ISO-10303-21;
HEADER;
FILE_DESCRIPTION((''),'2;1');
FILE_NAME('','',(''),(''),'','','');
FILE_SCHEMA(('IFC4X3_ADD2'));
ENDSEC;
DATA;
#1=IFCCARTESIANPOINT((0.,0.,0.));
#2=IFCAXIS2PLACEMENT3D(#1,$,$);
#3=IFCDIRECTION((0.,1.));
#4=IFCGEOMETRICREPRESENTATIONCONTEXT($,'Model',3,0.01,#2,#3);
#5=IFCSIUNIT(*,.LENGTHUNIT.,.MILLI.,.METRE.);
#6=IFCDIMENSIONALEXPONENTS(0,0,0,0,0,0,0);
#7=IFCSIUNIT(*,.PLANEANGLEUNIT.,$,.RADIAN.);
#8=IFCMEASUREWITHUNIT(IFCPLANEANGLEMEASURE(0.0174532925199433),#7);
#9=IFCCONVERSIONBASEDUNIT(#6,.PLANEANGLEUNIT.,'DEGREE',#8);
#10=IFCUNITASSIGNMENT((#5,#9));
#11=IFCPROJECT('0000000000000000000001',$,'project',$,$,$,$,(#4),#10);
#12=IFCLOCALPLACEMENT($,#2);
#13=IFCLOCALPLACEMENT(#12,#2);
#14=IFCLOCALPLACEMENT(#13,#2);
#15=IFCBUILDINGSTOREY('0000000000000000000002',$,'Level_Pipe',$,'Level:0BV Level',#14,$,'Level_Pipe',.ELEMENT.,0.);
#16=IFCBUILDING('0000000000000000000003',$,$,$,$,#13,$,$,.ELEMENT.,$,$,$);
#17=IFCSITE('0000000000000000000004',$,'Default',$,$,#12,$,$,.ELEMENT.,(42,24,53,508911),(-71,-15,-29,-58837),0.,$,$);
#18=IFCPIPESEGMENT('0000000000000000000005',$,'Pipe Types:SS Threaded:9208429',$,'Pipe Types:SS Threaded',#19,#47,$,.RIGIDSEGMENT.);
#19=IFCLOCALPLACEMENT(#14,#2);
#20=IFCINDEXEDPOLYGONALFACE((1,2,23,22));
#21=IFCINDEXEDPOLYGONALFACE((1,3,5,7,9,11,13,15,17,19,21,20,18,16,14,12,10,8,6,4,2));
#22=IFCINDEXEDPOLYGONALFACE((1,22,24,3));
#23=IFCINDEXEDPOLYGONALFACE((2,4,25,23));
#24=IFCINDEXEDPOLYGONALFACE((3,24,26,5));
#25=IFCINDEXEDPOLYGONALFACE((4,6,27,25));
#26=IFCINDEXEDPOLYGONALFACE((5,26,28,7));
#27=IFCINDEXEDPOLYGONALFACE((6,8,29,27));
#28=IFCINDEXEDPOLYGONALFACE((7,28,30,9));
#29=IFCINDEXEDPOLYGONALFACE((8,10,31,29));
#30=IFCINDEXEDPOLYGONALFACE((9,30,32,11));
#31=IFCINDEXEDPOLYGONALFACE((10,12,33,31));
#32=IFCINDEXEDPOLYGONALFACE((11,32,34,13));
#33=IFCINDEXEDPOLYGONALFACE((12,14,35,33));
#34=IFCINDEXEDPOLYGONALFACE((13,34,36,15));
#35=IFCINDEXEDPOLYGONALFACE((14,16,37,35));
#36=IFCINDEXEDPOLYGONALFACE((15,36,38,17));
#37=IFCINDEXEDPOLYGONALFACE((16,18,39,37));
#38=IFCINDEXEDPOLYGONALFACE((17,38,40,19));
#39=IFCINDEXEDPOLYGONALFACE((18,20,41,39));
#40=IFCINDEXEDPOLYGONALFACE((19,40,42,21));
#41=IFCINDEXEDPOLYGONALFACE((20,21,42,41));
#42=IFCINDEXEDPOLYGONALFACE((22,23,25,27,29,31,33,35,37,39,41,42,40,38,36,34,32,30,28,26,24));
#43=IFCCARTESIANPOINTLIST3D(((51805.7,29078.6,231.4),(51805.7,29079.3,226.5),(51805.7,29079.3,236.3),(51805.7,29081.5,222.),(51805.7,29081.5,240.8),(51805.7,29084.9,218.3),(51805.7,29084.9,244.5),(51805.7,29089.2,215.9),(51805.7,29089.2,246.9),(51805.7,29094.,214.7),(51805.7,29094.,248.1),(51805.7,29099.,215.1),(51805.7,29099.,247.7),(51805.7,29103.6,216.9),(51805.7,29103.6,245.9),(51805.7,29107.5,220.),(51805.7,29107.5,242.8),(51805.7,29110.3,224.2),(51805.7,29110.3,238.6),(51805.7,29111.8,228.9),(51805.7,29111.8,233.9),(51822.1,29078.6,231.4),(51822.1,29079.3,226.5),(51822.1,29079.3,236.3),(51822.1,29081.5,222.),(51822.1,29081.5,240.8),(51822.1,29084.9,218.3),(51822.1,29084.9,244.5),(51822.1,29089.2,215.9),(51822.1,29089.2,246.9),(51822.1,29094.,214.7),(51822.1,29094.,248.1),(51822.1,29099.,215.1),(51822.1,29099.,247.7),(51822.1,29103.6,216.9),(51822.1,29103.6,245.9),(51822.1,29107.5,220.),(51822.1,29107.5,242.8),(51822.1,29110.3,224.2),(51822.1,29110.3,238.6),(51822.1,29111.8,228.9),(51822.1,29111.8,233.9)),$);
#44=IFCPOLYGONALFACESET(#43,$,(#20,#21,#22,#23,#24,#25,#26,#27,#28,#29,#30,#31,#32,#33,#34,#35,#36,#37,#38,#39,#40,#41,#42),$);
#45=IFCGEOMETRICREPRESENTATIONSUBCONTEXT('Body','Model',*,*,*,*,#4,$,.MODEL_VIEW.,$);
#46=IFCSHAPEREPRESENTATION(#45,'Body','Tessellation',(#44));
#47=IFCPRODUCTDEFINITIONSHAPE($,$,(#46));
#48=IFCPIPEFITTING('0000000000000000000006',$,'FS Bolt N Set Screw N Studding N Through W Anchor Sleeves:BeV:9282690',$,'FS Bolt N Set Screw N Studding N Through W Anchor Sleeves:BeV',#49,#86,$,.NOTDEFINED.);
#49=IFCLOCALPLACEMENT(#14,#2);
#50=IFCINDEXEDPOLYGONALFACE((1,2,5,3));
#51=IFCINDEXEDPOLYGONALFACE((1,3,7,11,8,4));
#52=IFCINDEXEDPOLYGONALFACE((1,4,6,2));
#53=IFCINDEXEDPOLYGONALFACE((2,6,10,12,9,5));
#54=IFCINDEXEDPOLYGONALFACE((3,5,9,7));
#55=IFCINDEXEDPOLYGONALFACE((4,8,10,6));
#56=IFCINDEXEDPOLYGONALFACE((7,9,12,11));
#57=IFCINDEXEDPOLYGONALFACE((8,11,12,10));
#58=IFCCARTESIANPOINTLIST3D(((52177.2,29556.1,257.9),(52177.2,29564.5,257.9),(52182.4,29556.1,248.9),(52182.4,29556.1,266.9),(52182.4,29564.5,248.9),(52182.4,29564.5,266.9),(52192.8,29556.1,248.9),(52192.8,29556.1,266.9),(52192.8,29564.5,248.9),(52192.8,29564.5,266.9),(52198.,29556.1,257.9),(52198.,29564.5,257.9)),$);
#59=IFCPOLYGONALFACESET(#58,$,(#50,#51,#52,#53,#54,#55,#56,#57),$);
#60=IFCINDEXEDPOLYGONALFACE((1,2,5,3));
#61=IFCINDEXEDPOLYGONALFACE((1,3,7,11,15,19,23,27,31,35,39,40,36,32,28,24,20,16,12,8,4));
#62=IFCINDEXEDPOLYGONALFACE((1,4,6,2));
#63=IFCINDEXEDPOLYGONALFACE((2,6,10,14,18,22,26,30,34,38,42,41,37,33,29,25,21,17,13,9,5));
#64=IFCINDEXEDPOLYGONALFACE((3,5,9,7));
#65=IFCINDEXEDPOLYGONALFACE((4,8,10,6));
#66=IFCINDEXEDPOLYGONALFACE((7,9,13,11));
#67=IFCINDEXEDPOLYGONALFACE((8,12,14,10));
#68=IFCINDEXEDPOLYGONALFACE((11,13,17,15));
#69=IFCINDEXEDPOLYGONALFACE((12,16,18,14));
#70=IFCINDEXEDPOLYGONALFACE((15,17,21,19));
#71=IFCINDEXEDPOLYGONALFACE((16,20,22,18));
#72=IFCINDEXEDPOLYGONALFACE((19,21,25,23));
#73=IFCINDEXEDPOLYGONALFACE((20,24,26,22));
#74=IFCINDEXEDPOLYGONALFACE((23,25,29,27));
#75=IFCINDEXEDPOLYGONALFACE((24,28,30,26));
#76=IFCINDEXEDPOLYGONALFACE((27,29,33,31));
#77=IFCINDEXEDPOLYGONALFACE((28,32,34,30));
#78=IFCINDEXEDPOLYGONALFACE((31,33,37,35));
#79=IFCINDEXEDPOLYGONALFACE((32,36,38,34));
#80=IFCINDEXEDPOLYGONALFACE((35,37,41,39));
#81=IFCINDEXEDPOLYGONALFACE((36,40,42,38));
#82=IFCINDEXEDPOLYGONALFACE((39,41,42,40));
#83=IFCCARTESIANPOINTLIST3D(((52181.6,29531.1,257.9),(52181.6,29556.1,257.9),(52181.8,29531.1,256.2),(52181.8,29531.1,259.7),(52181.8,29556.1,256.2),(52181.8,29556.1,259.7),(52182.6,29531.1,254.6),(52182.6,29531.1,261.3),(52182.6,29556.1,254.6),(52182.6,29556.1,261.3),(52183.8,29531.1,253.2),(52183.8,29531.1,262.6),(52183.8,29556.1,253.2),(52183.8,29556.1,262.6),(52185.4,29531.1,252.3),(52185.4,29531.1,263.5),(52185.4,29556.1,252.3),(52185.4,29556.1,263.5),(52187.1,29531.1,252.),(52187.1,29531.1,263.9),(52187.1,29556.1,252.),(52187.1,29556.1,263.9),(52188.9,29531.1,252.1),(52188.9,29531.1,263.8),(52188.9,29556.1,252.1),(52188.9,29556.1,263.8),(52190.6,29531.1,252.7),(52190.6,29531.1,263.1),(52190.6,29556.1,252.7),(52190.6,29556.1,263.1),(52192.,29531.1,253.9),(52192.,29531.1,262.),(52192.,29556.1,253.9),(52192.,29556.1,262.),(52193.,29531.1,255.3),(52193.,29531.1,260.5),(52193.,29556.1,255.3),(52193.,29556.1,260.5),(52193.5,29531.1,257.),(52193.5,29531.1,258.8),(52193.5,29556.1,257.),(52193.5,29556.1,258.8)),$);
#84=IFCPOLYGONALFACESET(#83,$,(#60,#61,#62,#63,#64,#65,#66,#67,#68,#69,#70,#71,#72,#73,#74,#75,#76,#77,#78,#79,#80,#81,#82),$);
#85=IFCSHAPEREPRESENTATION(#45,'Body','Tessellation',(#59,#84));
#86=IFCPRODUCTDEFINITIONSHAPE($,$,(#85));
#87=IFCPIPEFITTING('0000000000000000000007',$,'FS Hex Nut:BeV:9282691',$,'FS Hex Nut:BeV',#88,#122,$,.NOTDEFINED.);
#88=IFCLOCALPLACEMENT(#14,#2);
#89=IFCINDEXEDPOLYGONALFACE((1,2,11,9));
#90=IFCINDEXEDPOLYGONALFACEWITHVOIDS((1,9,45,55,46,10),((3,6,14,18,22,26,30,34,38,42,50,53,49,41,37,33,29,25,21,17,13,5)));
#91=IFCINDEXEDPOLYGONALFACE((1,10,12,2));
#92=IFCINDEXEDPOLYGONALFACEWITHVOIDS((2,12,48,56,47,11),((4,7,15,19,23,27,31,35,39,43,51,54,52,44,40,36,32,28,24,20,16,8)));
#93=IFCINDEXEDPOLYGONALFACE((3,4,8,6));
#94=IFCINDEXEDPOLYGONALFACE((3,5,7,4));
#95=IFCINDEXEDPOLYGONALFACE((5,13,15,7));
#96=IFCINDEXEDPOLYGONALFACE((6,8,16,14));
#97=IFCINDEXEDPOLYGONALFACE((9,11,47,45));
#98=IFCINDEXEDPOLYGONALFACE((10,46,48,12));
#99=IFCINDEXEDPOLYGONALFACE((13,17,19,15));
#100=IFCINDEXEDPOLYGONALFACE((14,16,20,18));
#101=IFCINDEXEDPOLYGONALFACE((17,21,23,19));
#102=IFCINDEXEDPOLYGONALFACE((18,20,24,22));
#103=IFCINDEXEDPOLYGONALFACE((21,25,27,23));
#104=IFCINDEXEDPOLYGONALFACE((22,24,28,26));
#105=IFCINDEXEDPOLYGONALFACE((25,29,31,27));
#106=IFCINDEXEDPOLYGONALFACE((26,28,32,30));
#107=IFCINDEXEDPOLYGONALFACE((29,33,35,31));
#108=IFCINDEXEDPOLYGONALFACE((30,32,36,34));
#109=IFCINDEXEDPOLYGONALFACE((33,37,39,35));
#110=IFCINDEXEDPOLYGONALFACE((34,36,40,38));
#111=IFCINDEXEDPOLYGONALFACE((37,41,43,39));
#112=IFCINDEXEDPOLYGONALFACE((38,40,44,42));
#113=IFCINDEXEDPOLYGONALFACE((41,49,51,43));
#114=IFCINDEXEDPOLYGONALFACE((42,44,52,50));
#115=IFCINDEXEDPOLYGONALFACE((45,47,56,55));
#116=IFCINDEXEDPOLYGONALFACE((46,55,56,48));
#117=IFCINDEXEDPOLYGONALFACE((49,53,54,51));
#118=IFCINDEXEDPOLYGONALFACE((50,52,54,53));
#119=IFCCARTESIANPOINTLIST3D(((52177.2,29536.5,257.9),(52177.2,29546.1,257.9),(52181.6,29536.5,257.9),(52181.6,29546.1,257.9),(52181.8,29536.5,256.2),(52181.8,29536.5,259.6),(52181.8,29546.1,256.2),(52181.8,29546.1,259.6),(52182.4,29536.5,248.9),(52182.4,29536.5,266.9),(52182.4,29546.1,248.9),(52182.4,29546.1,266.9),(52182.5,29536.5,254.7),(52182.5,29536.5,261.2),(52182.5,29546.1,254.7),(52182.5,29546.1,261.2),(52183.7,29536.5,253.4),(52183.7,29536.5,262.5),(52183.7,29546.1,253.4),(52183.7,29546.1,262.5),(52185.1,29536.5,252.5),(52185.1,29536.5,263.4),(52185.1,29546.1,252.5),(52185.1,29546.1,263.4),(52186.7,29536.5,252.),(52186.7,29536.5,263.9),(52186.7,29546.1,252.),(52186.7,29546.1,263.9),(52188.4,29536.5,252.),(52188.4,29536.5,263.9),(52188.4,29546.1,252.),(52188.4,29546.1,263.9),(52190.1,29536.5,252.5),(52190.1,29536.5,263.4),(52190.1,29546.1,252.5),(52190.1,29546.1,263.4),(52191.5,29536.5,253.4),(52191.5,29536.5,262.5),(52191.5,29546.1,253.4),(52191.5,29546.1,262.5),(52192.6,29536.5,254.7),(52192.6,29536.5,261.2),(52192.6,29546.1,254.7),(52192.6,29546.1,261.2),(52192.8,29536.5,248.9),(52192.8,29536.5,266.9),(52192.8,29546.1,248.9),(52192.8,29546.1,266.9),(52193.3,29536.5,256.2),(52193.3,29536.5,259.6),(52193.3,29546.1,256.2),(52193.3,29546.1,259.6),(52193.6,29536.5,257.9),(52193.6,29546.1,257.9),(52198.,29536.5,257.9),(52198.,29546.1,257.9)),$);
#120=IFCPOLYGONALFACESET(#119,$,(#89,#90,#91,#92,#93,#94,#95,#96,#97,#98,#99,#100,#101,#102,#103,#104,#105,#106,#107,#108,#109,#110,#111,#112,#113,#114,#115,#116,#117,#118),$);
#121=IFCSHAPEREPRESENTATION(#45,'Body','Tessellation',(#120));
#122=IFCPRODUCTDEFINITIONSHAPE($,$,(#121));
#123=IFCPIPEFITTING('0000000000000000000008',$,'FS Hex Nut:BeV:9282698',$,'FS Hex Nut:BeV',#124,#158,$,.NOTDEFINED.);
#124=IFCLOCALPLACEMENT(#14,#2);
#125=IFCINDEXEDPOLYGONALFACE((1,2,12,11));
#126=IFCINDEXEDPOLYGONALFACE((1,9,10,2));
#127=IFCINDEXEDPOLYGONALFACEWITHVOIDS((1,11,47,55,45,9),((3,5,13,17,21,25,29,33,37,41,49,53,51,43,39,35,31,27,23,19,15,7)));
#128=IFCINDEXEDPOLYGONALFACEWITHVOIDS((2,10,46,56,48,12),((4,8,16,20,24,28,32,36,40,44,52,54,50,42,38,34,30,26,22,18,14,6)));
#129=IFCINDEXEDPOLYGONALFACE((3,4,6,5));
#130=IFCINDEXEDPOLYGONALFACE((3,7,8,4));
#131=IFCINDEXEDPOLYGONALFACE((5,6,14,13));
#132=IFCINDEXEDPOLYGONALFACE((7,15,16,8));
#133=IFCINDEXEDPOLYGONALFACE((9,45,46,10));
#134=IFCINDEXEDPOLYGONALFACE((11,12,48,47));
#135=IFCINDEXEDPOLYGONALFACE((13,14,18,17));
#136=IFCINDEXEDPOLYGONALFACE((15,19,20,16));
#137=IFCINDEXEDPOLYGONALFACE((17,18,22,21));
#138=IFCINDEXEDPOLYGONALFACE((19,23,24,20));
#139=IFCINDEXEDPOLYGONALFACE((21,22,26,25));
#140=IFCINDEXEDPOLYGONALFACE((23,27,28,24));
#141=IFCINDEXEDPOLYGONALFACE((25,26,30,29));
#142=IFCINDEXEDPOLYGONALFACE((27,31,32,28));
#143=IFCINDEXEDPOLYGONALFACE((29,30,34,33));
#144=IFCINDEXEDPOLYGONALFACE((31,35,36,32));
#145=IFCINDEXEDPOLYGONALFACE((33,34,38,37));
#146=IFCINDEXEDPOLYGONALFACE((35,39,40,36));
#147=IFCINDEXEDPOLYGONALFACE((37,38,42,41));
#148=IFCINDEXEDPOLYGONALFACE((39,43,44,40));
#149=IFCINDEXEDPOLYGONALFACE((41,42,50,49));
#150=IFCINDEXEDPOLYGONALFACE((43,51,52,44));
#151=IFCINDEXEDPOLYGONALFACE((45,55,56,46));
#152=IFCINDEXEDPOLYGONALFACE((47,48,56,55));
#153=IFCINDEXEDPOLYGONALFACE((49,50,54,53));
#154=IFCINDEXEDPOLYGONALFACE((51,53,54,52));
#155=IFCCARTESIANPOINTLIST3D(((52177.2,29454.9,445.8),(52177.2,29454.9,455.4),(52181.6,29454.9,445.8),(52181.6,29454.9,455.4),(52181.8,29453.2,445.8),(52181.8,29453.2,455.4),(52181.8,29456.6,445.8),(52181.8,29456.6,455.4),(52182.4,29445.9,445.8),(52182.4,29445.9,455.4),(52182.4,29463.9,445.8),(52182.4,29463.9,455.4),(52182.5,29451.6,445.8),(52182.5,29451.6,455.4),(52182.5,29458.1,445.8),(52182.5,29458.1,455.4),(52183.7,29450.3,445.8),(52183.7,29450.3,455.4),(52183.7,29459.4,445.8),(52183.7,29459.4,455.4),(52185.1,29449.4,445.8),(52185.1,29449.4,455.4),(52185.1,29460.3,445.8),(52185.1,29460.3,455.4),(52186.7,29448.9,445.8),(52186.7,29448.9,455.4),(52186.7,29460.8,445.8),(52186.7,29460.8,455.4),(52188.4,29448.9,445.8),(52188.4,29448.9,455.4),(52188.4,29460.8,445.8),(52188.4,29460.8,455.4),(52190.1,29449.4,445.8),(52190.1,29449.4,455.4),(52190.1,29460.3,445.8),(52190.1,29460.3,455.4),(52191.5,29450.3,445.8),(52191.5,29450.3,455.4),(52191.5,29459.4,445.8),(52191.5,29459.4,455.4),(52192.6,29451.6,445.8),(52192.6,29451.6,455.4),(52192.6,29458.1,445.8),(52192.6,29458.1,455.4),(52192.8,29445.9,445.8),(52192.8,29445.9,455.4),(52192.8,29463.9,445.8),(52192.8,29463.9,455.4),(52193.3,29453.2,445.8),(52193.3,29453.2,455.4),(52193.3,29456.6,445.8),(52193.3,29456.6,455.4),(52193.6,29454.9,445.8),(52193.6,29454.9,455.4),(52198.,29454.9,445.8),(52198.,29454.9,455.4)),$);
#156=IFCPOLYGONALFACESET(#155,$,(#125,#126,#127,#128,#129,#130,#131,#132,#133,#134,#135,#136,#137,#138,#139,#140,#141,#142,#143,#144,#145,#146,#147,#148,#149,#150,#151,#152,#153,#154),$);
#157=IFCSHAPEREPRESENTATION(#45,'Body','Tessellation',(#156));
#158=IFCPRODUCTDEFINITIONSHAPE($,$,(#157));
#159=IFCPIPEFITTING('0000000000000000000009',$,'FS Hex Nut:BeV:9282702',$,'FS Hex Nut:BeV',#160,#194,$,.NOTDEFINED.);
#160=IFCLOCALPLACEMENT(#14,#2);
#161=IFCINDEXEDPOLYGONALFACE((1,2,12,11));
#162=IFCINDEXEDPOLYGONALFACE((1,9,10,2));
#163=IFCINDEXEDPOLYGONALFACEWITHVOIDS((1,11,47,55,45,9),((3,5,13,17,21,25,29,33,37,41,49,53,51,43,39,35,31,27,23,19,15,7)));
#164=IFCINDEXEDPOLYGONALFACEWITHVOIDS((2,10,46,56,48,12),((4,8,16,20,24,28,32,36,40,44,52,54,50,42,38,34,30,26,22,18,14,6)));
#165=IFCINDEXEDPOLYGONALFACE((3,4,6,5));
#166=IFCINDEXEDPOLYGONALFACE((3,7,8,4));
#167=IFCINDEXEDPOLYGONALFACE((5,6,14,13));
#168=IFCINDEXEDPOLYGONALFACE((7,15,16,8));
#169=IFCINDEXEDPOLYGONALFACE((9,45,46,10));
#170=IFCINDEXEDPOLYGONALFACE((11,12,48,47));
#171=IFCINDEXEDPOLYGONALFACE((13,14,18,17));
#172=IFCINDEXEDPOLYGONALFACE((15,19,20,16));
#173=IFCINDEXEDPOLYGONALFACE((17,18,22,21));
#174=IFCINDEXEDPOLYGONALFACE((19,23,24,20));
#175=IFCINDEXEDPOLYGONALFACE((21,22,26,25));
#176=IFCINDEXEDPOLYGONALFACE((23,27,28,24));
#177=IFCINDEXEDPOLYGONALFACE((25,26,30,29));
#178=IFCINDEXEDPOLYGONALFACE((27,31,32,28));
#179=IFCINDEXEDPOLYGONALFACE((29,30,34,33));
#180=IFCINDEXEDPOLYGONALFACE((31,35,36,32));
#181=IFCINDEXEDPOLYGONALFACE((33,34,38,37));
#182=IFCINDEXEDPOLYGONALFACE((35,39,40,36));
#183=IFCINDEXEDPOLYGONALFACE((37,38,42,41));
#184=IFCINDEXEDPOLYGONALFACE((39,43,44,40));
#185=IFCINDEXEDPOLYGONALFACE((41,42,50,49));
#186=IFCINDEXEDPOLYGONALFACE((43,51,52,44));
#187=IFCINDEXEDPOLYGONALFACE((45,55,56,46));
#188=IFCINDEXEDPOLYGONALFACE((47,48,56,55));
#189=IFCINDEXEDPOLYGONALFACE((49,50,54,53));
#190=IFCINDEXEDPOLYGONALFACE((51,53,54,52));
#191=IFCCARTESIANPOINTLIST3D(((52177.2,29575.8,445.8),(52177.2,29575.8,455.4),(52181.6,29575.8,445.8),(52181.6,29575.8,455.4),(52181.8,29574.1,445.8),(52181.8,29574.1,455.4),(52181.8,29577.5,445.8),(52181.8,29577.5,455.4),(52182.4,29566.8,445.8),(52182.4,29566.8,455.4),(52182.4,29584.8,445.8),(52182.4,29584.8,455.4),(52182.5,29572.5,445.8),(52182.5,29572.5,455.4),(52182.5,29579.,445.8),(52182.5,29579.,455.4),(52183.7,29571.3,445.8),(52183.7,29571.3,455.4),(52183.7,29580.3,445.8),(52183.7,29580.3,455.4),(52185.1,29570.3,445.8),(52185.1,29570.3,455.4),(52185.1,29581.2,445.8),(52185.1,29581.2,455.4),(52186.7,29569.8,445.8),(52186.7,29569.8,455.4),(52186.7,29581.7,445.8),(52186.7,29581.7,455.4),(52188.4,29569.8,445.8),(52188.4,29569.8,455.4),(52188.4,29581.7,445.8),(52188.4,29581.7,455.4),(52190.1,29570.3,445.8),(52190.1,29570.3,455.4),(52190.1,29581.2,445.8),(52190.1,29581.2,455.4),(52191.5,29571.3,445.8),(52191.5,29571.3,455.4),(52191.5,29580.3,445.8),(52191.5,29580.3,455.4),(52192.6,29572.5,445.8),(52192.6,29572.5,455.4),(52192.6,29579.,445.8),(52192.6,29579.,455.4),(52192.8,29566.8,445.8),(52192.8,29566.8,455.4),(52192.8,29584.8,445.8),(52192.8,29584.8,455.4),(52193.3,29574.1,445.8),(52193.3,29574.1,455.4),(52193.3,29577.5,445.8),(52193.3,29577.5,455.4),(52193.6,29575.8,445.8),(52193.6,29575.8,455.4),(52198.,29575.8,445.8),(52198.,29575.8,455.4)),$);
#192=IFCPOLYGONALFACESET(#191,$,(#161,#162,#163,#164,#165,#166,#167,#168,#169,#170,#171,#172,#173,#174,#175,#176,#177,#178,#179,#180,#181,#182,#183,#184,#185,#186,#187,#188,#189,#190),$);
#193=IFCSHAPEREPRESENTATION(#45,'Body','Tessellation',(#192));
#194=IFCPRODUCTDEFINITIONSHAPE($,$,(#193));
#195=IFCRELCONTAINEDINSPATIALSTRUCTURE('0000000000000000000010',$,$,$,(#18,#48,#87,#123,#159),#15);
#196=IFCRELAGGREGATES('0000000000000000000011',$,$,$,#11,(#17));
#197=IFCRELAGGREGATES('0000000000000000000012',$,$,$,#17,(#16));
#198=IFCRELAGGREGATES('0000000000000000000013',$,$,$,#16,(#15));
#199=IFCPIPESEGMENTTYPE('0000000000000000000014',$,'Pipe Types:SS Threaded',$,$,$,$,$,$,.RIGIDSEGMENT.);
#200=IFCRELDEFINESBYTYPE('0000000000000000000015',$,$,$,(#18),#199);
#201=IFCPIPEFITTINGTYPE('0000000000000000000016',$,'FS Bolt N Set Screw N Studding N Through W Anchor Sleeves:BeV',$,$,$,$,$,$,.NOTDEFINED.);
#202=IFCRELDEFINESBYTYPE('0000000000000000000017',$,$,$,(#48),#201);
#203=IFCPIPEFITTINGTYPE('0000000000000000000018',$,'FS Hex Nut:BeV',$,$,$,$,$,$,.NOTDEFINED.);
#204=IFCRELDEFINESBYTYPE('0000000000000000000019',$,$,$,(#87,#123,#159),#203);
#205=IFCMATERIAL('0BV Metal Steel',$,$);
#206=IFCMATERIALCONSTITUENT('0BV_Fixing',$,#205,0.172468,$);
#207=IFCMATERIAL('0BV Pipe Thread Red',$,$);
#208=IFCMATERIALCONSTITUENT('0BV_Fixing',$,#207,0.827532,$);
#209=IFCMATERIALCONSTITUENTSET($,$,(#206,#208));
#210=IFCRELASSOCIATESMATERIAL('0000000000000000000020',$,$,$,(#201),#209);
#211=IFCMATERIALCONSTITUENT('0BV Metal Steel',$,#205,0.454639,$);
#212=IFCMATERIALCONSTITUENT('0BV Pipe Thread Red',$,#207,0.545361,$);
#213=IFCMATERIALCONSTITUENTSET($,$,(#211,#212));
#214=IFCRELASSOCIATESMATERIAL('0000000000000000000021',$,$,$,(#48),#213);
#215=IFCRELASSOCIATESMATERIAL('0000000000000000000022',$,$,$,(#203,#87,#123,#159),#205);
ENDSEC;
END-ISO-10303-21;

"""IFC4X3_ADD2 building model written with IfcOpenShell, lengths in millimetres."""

from ifc_helpers import new_model, entity, si_unit, converted_unit, direction, frame, frame_2d, origin, origin_2d_with_axis, place, context, subcontext, project, spatial, polyline, circle_curve, parameter, trimmed, segment, composite_curve, circle, outline, extrude, source, transform, mapped, material, constituent, constituent_set, type_object, type_shapes, element, save


model = new_model("IFC4X3_ADD2")

# Units and contexts
model_context = context("Model", 3, precision=0.01, world=origin(), true_north=direction((0.0, 1.0)))
body_context = subcontext(model_context, "Body", "Model", "MODEL_VIEW")
ifc_project = project(units=[si_unit("LENGTHUNIT", "METRE", prefix="MILLI"), converted_unit("PLANEANGLEUNIT", "DEGREE", entity("IfcPlaneAngleMeasure", 0.0174532925199433), si_unit("PLANEANGLEUNIT", "RADIAN"), dimensions=[0, 0, 0, 0, 0, 0, 0])], contexts=[model_context])

# Site, building, storey
site_placement = place(None, origin())
site = spatial("IfcSite", under=ifc_project, at=site_placement, Name="Default", CompositionType="ELEMENT", RefLatitude=(42, 24, 53, 508911), RefLongitude=(-71, -15, -29, -58837), RefElevation=0.0)
building_placement = place(site_placement, origin())
building = spatial("IfcBuilding", under=site, at=building_placement, CompositionType="ELEMENT")
storey_placement = place(building_placement, origin())
storey = spatial("IfcBuildingStorey", under=building, at=storey_placement, Name="Level_Pipe", ObjectType="Level:0BV Level", LongName="Level_Pipe", CompositionType="ELEMENT", Elevation=0.0)

# Pipe segment
pipe_segment_type_1 = type_object("IfcPipeSegmentType", Name="Pipe Types:SS Threaded", PredefinedType="RIGIDSEGMENT")
pipe_segment_1_placement = place(storey_placement, frame((51805.7, 29077.0, 249.7)))
element("IfcPipeSegment", 1, at=pipe_segment_1_placement, inside=storey, type_object=pipe_segment_type_1, Name="Pipe Types:SS Threaded:9208429", ObjectType="Pipe Types:SS Threaded", PredefinedType="RIGIDSEGMENT", context=body_context, shape_type="SweptSolid", body=[
    extrude(circle(Radius=16.7, at=frame_2d((0.0, 0.0), x_axis=(1.0, 0.0))), frame((0.0, 18.3, -18.3), z_axis=(1.0, 0.0, -0.000012), x_axis=(0.0, -1.0, 0.0)), (0.0, 0.0, 1.0), 16.5),
])

# Pipe fittings
ifc_material_1 = material(Name="0BV Metal Steel")
ifc_constituent_1 = constituent(ifc_material_1, Name="0BV Metal Steel", fraction=0.454639)
ifc_material_2 = material(Name="0BV Pipe Thread Red")
ifc_constituent_2 = constituent(ifc_material_2, Name="0BV Pipe Thread Red", fraction=0.545361)
ifc_constituent_set_1 = constituent_set(constituents=[ifc_constituent_1, ifc_constituent_2])
ifc_constituent_3 = constituent(ifc_material_1, Name="0BV_Fixing", fraction=0.172468)
ifc_constituent_4 = constituent(ifc_material_2, Name="0BV_Fixing", fraction=0.827532)
ifc_constituent_set_2 = constituent_set(constituents=[ifc_constituent_3, ifc_constituent_4])
pipe_fitting_type_1 = type_object("IfcPipeFittingType", Name="FS Bolt N Set Screw N Studding N Through W Anchor Sleeves:BeV", PredefinedType="NOTDEFINED", material=ifc_constituent_set_2)
shared_shape_1 = source(origin(), body_context, "Body", "SweptSolid", [
    extrude(outline(polyline([(-5.2, -9.0), (5.2, -9.0), (10.4, 0.0), (5.2, 9.0), (-5.2, 9.0), (-10.4, 0.0), (-5.2, -9.0)])), frame((-8.4, 0.0, 0.0), z_axis=(1.0, 0.0, 0.0), x_axis=(0.0, -1.0, 0.0)), (0.0, 0.0, 1.0), 8.4),
    extrude(circle(Radius=6.0, at=frame_2d((0.0, 0.0), x_axis=(1.0, 0.0))), frame((0.0, 0.0, 0.0), z_axis=(1.0, 0.0, 0.0), x_axis=(0.0, -1.0, 0.0)), (0.0, 0.0, 1.0), 25.0),
])
type_shapes(pipe_fitting_type_1, [shared_shape_1])
pipe_fitting_1_placement = place(storey_placement, frame((52187.6, 29556.1, 257.9), z_axis=(0.0, 0.0, 1.0), x_axis=(0.0, -1.0, 0.0)))
element("IfcPipeFitting", 2, at=pipe_fitting_1_placement, inside=storey, type_object=pipe_fitting_type_1, material=ifc_constituent_set_1, Name="FS Bolt N Set Screw N Studding N Through W Anchor Sleeves:BeV:9282690", ObjectType="FS Bolt N Set Screw N Studding N Through W Anchor Sleeves:BeV", PredefinedType="NOTDEFINED", context=body_context, shape_type="MappedRepresentation", body=[
    mapped(shared_shape_1, transform((0.0, 0.0, 0.0), scale=1.0)),
])
pipe_fitting_type_2 = type_object("IfcPipeFittingType", Name="FS Hex Nut:BeV", PredefinedType="NOTDEFINED", material=ifc_material_1)
shared_shape_2 = source(origin(), body_context, "Body", "SweptSolid", [
    extrude(outline(polyline([(-5.2, -9.0), (5.2, -9.0), (10.4, 0.0), (5.2, 9.0), (-5.2, 9.0), (-10.4, 0.0), (-5.2, -9.0)]), holes=[composite_curve([segment(trimmed(circle_curve(origin_2d_with_axis(), 6.0), [parameter(0.0)], [parameter(180.0)], True, "PARAMETER"), False, "CONTINUOUS"), segment(trimmed(circle_curve(origin_2d_with_axis(), 6.0), [parameter(180.0)], [parameter(0.0)], True, "PARAMETER"), False, "CONTINUOUS")], self_intersect=False)]), frame((0.0, 10.4, 9.0), z_axis=(1.0, 0.0, 0.0), x_axis=(0.0, -1.0, 0.0)), (0.0, 0.0, 1.0), 9.6),
])
type_shapes(pipe_fitting_type_2, [shared_shape_2])
for number, where, z_axis, x_axis, name in (
    (3, (52177.2, 29546.1, 248.9), (0.0, 0.0, 1.0), (0.0, -1.0, 0.0), "FS Hex Nut:BeV:9282691"),
    (4, (52177.2, 29463.9, 455.4), (0.0, -1.0, 0.0), (0.0, 0.0, -1.0), "FS Hex Nut:BeV:9282698"),
    (5, (52177.2, 29584.8, 455.4), (0.0, -1.0, 0.0), (0.0, 0.0, -1.0), "FS Hex Nut:BeV:9282702"),
):
    element("IfcPipeFitting", number, at=place(storey_placement, frame(where, z_axis=z_axis, x_axis=x_axis)), inside=storey, type_object=pipe_fitting_type_2, material=ifc_material_1, Name=name, ObjectType="FS Hex Nut:BeV", PredefinedType="NOTDEFINED", context=body_context, shape_type="MappedRepresentation", body=[
        mapped(shared_shape_2, transform((0.0, 0.0, 0.0), scale=1.0)),
    ])

save(model, "model.ifc")
